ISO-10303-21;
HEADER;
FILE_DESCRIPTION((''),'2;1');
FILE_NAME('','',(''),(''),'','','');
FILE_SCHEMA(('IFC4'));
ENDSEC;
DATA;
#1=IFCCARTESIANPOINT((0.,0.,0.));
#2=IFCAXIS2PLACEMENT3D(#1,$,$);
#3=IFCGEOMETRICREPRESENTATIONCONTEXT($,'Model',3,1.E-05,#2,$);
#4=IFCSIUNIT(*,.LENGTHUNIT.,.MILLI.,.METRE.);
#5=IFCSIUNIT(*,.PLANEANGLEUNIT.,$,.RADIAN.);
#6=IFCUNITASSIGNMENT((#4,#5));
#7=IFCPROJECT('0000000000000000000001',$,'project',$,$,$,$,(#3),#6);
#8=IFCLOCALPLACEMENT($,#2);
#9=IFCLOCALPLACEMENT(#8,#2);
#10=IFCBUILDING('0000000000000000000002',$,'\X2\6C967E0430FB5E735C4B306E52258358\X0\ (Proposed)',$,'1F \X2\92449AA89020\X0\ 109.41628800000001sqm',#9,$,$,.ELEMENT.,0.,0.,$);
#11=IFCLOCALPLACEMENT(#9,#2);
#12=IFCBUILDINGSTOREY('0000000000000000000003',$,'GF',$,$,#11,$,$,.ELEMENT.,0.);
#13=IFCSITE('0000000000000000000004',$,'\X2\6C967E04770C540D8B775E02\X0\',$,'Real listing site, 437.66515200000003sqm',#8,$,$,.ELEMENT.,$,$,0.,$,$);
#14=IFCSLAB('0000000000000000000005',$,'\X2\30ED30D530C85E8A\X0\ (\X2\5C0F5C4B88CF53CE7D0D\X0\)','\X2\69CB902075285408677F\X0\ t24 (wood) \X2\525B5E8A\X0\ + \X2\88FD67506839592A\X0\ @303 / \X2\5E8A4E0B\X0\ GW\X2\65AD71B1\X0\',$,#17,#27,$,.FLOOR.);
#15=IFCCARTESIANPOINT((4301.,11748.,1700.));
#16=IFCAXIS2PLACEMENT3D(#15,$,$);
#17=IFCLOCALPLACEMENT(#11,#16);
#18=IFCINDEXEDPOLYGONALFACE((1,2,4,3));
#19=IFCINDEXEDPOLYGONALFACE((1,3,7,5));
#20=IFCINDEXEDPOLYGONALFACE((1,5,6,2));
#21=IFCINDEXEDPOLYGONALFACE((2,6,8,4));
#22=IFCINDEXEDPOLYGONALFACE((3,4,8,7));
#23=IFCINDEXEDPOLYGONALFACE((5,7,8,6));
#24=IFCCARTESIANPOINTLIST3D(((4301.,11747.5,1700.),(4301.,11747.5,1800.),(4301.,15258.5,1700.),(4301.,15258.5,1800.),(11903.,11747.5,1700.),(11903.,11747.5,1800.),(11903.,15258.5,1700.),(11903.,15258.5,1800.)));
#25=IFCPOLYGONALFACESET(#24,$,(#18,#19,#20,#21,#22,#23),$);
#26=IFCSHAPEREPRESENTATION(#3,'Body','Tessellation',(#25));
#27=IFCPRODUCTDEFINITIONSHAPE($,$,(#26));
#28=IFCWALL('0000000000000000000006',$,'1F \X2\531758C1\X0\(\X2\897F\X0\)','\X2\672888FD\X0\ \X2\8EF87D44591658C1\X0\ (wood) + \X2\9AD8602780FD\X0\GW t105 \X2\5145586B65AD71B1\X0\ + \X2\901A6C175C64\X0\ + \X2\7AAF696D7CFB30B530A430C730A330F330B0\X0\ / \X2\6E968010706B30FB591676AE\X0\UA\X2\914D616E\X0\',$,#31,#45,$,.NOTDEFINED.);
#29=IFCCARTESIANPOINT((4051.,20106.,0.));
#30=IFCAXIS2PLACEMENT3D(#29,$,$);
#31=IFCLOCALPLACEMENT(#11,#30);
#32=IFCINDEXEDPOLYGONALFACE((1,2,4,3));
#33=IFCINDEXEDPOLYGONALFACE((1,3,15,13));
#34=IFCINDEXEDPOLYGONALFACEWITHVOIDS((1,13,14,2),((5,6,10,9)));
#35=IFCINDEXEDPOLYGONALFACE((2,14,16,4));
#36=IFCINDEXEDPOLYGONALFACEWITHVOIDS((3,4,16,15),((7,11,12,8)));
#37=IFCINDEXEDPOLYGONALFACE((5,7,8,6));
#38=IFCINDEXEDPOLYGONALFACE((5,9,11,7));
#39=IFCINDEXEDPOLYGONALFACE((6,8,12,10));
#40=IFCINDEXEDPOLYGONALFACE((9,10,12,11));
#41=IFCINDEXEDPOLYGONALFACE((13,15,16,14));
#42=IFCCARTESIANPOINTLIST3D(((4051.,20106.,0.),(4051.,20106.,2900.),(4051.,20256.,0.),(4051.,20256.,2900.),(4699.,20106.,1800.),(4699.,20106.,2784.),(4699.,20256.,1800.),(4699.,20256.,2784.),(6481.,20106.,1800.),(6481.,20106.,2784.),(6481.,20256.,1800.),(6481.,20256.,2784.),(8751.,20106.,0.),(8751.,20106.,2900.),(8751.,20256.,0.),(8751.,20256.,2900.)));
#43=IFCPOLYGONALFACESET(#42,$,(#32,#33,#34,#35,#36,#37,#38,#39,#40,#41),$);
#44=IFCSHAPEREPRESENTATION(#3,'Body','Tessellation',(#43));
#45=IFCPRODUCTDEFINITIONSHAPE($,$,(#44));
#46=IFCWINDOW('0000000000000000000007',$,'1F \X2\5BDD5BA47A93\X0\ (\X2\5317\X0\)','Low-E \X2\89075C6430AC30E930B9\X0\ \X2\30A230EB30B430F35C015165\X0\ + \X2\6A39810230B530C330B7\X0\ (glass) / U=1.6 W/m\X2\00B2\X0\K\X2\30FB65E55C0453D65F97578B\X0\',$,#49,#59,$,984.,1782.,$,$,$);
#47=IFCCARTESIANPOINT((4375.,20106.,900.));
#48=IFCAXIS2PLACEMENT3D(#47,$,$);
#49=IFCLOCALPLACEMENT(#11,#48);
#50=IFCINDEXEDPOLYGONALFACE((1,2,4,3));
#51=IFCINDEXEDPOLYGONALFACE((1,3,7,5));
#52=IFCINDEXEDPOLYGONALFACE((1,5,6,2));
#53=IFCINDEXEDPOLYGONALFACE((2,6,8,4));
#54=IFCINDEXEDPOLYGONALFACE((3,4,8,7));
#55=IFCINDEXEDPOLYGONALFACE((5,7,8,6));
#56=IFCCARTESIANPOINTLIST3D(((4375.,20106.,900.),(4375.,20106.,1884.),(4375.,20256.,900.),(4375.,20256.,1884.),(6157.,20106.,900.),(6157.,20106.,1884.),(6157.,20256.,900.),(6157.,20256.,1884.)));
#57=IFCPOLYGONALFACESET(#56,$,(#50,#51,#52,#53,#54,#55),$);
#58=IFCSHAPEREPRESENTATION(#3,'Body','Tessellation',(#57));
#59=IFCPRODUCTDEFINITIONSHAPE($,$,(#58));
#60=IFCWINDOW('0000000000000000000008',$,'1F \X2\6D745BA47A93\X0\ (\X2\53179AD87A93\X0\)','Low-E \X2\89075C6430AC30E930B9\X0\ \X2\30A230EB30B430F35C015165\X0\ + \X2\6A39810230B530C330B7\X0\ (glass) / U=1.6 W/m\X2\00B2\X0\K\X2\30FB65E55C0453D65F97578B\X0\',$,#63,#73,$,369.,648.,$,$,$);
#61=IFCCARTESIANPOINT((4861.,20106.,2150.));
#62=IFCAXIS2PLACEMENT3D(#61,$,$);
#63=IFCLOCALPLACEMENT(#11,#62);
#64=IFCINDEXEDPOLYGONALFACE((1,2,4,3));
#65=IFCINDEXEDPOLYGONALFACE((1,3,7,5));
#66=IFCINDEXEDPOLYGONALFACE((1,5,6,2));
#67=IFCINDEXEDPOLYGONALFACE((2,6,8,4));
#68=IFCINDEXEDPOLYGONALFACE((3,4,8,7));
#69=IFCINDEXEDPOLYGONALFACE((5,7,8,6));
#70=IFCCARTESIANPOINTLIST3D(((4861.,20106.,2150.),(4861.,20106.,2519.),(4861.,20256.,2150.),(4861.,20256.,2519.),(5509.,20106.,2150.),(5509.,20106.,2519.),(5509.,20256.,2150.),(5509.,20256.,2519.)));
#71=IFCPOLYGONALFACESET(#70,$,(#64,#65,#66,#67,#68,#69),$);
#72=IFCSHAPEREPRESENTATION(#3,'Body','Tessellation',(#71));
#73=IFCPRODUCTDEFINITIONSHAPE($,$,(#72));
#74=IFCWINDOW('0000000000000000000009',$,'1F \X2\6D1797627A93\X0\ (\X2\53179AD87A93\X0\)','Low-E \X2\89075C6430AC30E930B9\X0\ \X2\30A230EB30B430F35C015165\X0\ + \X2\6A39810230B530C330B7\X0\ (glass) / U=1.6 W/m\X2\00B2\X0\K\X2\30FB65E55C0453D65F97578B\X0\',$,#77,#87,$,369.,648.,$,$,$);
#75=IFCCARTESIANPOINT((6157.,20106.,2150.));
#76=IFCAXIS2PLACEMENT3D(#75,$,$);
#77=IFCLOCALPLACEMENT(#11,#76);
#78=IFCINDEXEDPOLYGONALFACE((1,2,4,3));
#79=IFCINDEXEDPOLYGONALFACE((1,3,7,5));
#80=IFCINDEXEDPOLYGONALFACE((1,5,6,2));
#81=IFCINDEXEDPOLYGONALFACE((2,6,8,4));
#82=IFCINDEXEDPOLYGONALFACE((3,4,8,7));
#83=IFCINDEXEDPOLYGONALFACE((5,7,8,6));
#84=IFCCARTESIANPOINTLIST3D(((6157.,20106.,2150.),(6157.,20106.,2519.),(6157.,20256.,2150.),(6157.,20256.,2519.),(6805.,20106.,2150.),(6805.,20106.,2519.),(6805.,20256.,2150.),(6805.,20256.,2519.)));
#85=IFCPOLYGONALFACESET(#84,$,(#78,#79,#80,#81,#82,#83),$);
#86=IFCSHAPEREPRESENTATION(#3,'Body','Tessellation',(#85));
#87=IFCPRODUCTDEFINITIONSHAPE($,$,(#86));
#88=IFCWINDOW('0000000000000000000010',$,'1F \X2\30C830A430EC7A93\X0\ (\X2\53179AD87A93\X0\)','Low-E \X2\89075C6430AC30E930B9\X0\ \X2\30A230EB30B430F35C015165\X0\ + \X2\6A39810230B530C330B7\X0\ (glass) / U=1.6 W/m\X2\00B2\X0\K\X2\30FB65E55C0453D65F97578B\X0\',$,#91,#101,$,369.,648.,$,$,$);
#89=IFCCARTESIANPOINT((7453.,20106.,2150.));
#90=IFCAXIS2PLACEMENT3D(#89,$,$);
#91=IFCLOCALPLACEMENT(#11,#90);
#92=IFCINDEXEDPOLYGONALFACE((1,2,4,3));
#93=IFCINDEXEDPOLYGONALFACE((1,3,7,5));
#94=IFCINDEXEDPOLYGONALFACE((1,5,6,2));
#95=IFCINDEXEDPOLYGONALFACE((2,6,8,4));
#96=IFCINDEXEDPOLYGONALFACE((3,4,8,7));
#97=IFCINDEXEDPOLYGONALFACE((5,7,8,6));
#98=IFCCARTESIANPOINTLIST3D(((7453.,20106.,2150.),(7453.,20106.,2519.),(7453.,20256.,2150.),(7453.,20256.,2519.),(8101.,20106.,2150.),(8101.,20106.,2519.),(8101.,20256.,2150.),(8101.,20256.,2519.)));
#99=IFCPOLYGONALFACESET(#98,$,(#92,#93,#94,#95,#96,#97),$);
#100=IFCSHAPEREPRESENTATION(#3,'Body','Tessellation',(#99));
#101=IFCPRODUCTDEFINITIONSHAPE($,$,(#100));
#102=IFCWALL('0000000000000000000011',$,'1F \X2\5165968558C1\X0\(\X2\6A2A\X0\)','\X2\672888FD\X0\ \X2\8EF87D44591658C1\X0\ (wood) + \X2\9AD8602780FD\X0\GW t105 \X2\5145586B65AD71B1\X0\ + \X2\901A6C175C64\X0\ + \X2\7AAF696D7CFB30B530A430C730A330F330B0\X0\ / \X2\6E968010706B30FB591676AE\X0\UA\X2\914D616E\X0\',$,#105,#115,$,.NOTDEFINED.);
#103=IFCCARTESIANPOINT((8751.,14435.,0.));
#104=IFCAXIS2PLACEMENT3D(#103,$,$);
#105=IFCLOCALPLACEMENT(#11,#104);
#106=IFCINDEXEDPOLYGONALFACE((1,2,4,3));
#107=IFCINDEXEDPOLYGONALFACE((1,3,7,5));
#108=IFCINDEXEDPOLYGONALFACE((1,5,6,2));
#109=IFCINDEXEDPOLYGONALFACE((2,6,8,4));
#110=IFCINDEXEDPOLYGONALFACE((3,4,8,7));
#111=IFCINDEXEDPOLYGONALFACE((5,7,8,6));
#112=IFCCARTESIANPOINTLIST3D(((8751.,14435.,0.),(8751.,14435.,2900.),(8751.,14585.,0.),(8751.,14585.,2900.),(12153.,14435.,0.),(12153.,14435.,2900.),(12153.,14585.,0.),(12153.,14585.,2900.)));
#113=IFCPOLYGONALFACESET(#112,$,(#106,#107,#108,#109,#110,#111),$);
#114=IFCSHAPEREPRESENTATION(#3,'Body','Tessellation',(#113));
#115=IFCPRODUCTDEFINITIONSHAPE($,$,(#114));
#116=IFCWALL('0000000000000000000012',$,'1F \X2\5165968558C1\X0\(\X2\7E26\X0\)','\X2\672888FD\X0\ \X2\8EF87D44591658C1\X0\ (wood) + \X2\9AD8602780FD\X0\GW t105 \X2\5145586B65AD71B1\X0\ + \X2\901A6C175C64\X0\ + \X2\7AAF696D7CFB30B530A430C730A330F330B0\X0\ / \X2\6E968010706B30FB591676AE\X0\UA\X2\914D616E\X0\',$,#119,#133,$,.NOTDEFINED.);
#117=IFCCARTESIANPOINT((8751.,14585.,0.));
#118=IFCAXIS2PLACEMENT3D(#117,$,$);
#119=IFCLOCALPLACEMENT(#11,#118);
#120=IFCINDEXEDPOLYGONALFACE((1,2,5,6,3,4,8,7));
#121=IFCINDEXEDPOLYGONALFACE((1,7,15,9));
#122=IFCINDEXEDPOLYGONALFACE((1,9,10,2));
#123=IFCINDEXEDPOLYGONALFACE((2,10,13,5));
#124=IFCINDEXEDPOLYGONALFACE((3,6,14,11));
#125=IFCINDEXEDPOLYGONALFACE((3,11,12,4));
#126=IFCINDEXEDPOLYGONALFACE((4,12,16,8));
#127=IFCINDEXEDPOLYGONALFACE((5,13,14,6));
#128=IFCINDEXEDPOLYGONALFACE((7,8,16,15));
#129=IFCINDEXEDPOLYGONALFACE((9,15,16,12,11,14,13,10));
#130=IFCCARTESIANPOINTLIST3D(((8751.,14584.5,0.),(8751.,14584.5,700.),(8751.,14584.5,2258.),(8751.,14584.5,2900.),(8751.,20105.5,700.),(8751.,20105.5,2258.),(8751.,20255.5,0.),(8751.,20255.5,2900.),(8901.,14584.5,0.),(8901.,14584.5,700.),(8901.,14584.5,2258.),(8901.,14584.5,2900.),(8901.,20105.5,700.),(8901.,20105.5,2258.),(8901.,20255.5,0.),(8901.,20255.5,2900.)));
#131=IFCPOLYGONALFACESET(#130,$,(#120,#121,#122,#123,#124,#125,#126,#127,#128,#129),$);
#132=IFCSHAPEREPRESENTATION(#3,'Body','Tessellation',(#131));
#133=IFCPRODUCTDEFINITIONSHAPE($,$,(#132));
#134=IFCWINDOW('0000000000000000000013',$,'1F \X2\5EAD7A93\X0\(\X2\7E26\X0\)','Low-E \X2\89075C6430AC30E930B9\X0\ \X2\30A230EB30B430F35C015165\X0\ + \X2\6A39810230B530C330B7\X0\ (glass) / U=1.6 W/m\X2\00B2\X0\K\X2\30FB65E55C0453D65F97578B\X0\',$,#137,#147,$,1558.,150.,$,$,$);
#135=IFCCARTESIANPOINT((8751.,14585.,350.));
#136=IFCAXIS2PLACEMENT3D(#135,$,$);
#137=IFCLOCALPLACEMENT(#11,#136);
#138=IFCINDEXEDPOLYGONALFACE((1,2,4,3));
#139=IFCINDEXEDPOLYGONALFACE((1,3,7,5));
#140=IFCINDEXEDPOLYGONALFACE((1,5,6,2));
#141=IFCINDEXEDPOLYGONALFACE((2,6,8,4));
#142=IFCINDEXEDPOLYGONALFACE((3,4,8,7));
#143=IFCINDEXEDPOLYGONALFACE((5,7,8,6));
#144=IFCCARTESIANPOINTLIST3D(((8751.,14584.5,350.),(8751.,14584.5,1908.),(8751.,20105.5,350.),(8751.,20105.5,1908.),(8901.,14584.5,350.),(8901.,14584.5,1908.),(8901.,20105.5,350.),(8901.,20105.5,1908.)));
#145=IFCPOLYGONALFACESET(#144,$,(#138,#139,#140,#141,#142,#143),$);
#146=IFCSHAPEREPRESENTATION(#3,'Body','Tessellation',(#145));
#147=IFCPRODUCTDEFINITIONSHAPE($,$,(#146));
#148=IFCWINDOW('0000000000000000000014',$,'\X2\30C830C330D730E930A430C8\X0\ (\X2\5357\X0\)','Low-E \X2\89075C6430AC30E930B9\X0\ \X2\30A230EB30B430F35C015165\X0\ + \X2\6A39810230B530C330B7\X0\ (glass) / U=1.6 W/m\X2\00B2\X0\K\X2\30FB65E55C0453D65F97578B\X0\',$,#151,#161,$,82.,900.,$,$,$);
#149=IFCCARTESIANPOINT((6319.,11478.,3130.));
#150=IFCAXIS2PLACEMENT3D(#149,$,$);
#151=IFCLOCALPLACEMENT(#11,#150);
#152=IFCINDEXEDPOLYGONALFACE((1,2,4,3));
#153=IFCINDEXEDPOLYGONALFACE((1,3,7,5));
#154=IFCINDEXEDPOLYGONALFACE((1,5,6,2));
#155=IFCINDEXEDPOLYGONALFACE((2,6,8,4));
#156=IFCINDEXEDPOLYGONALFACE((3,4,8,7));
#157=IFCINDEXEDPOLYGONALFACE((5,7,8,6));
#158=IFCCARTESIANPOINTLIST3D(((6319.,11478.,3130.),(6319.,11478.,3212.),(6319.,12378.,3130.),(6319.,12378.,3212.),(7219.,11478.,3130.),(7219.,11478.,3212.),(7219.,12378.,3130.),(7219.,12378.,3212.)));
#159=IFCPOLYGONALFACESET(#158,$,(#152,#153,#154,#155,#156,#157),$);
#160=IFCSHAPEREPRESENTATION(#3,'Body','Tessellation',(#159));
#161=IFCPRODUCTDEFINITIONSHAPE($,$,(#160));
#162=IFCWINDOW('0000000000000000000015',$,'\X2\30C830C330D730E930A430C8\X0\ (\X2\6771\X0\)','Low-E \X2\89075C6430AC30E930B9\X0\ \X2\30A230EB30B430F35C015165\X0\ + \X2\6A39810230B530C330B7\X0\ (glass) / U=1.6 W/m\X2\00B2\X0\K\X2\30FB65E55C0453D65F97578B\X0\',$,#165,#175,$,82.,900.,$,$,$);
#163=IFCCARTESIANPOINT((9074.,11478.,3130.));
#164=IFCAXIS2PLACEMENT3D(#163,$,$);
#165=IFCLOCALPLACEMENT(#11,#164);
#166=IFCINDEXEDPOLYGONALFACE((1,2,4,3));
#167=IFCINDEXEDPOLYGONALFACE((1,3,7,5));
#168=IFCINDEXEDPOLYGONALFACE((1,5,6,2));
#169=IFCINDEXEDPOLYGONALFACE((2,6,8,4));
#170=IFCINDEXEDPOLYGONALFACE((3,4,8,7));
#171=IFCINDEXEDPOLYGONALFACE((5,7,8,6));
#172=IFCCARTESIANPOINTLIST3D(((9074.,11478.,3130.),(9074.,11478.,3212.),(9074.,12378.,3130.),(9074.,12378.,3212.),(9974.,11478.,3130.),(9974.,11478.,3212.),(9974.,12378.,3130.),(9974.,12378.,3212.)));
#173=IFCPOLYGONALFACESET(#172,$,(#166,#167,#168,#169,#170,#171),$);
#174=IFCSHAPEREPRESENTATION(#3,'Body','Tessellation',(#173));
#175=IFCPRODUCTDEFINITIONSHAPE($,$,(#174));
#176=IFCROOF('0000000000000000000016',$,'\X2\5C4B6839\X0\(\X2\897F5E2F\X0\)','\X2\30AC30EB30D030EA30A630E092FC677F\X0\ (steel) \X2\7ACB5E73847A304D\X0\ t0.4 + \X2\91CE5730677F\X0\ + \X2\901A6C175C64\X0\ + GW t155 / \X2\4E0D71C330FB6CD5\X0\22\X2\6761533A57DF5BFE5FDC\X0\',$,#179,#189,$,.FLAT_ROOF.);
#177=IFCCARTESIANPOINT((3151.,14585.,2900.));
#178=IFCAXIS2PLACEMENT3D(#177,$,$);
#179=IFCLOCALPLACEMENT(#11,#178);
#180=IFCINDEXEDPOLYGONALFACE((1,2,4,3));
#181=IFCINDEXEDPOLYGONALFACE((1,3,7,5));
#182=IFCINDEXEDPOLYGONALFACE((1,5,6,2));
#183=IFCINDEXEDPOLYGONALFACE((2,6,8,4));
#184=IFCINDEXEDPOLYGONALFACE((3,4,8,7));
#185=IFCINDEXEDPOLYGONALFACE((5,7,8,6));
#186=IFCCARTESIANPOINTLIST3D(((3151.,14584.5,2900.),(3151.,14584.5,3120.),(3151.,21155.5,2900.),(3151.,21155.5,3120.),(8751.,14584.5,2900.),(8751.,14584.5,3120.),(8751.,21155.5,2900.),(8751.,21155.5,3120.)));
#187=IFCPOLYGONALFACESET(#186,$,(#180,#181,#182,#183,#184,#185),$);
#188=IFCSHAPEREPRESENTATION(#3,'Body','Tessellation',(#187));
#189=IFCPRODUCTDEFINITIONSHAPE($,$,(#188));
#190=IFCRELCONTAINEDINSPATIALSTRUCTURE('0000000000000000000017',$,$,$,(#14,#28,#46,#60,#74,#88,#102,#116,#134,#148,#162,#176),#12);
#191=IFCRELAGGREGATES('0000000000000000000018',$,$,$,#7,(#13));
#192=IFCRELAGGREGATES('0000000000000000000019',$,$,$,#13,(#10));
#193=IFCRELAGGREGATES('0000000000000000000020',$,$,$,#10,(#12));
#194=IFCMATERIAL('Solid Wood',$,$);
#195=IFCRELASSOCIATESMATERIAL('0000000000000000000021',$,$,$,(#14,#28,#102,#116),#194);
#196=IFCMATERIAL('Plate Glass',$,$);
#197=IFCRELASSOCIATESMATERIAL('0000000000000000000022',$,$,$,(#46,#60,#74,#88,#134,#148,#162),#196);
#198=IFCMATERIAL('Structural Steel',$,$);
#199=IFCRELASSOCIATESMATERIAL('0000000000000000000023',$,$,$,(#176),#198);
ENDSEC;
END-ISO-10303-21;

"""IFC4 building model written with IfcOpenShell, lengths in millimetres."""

from ifc_helpers import new_model, si_unit, frame, frame_2d, origin, place, context, project, spatial, rectangle, extrude, material, element, fill, save


model = new_model("IFC4")

# Units and contexts
model_context = context("Model", 3, precision=1e-05, world=origin())
ifc_project = project(units=[si_unit("LENGTHUNIT", "METRE", prefix="MILLI"), si_unit("PLANEANGLEUNIT", "RADIAN")], contexts=[model_context])

# Site, building, storey
site_placement = place(None, origin())
site = spatial("IfcSite", under=ifc_project, at=site_placement, Name="沖縄県名護市", ObjectType="Real listing site, 437.66515200000003sqm", CompositionType="ELEMENT", RefElevation=0.0)
building_placement = place(site_placement, origin())
building = spatial("IfcBuilding", under=site, at=building_placement, Name="沖縄・平屋の別荘 (Proposed)", ObjectType="1F 鉄骨造 109.41628800000001sqm", CompositionType="ELEMENT", ElevationOfRefHeight=0.0, ElevationOfTerrain=0.0)
storey_placement = place(building_placement, origin())
storey = spatial("IfcBuildingStorey", under=building, at=storey_placement, Name="GF", CompositionType="ELEMENT", Elevation=0.0)

# Slab
ifc_material_1 = material(Name="Solid Wood")
slab_1_placement = place(storey_placement, frame((4301.0, 11748.0, 1700.0)))
element("IfcSlab", 1, at=slab_1_placement, inside=storey, material=ifc_material_1, Name="ロフト床 (小屋裏収納)", Description="構造用合板 t24 (wood) 剛床 + 製材根太 @303 / 床下 GW断熱", PredefinedType="FLOOR", context=model_context, shape_type="SweptSolid", body=[
    extrude(rectangle(XDim=7602.0, YDim=3511.0, at=frame_2d((3801.0, 1755.0))), frame((4301.0, 11748.0, 1700.0)), (0.0, 0.0, 1.0), 100.0),
])

# Wall, openings, windows
wall_1_placement = place(storey_placement, frame((4051.0, 20106.0, 0.0)))
wall_1 = element("IfcWall", 2, at=wall_1_placement, inside=storey, material=ifc_material_1, Name="1F 北壁(西)", Description="木製 軸組外壁 (wood) + 高性能GW t105 充填断熱 + 通気層 + 窯業系サイディング / 準耐火・外皮UA配慮", PredefinedType="NOTDEFINED", context=model_context, shape_type="SweptSolid", body=[
    extrude(rectangle(XDim=4700.0, YDim=150.0, at=frame_2d((2350.0, 75.0))), frame((4051.0, 20106.0, 0.0)), (0.0, 0.0, 1.0), 2900.0),
])
opening_1_placement = place(storey_placement, frame((4375.0, 20106.0, 900.0)))
opening_1 = element("IfcOpeningElement", 3, at=opening_1_placement, cuts=wall_1, PredefinedType="NOTDEFINED", context=model_context, shape_type="SweptSolid", body=[
    extrude(rectangle(XDim=1782.0, YDim=150.0, at=frame_2d((891.0, 75.0))), frame((4375.0, 20106.0, 900.0)), (0.0, 0.0, 1.0), 984.0),
])
opening_2_placement = place(storey_placement, frame((4861.0, 20106.0, 2150.0)))
opening_2 = element("IfcOpeningElement", 4, at=opening_2_placement, cuts=wall_1, PredefinedType="NOTDEFINED", context=model_context, shape_type="SweptSolid", body=[
    extrude(rectangle(XDim=648.0, YDim=150.0, at=frame_2d((324.0, 75.0))), frame((4861.0, 20106.0, 2150.0)), (0.0, 0.0, 1.0), 369.0),
])
opening_3_placement = place(storey_placement, frame((6157.0, 20106.0, 2150.0)))
opening_3 = element("IfcOpeningElement", 5, at=opening_3_placement, cuts=wall_1, PredefinedType="NOTDEFINED", context=model_context, shape_type="SweptSolid", body=[
    extrude(rectangle(XDim=648.0, YDim=150.0, at=frame_2d((324.0, 75.0))), frame((6157.0, 20106.0, 2150.0)), (0.0, 0.0, 1.0), 369.0),
])
opening_4_placement = place(storey_placement, frame((7453.0, 20106.0, 2150.0)))
opening_4 = element("IfcOpeningElement", 6, at=opening_4_placement, cuts=wall_1, PredefinedType="NOTDEFINED", context=model_context, shape_type="SweptSolid", body=[
    extrude(rectangle(XDim=648.0, YDim=150.0, at=frame_2d((324.0, 75.0))), frame((7453.0, 20106.0, 2150.0)), (0.0, 0.0, 1.0), 369.0),
])
ifc_material_2 = material(Name="Plate Glass")
window_1_placement = place(storey_placement, frame((4375.0, 20106.0, 900.0)))
window_1 = element("IfcWindow", 7, at=window_1_placement, inside=storey, material=ifc_material_2, Name="1F 寝室窓 (北)", Description="Low-E 複層ガラス アルゴン封入 + 樹脂サッシ (glass) / U=1.6 W/m²K・日射取得型", OverallHeight=984.0, OverallWidth=1782.0, context=model_context, shape_type="SweptSolid", body=[
    extrude(rectangle(XDim=1782.0, YDim=150.0, at=frame_2d((891.0, 75.0))), frame((4375.0, 20106.0, 900.0)), (0.0, 0.0, 1.0), 984.0),
])
fill(opening_1, window_1)
window_2_placement = place(storey_placement, frame((4861.0, 20106.0, 2150.0)))
window_2 = element("IfcWindow", 8, at=window_2_placement, inside=storey, material=ifc_material_2, Name="1F 浴室窓 (北高窓)", Description="Low-E 複層ガラス アルゴン封入 + 樹脂サッシ (glass) / U=1.6 W/m²K・日射取得型", OverallHeight=369.0, OverallWidth=648.0, context=model_context, shape_type="SweptSolid", body=[
    extrude(rectangle(XDim=648.0, YDim=150.0, at=frame_2d((324.0, 75.0))), frame((4861.0, 20106.0, 2150.0)), (0.0, 0.0, 1.0), 369.0),
])
fill(opening_2, window_2)
window_3_placement = place(storey_placement, frame((6157.0, 20106.0, 2150.0)))
window_3 = element("IfcWindow", 9, at=window_3_placement, inside=storey, material=ifc_material_2, Name="1F 洗面窓 (北高窓)", Description="Low-E 複層ガラス アルゴン封入 + 樹脂サッシ (glass) / U=1.6 W/m²K・日射取得型", OverallHeight=369.0, OverallWidth=648.0, context=model_context, shape_type="SweptSolid", body=[
    extrude(rectangle(XDim=648.0, YDim=150.0, at=frame_2d((324.0, 75.0))), frame((6157.0, 20106.0, 2150.0)), (0.0, 0.0, 1.0), 369.0),
])
fill(opening_3, window_3)
window_4_placement = place(storey_placement, frame((7453.0, 20106.0, 2150.0)))
window_4 = element("IfcWindow", 10, at=window_4_placement, inside=storey, material=ifc_material_2, Name="1F トイレ窓 (北高窓)", Description="Low-E 複層ガラス アルゴン封入 + 樹脂サッシ (glass) / U=1.6 W/m²K・日射取得型", OverallHeight=369.0, OverallWidth=648.0, context=model_context, shape_type="SweptSolid", body=[
    extrude(rectangle(XDim=648.0, YDim=150.0, at=frame_2d((324.0, 75.0))), frame((7453.0, 20106.0, 2150.0)), (0.0, 0.0, 1.0), 369.0),
])
fill(opening_4, window_4)

# Wall
wall_2_placement = place(storey_placement, frame((8751.0, 14435.0, 0.0)))
element("IfcWall", 11, at=wall_2_placement, inside=storey, material=ifc_material_1, Name="1F 入隅壁(横)", Description="木製 軸組外壁 (wood) + 高性能GW t105 充填断熱 + 通気層 + 窯業系サイディング / 準耐火・外皮UA配慮", PredefinedType="NOTDEFINED", context=model_context, shape_type="SweptSolid", body=[
    extrude(rectangle(XDim=3402.0, YDim=150.0, at=frame_2d((1701.0, 75.0))), frame((8751.0, 14435.0, 0.0)), (0.0, 0.0, 1.0), 2900.0),
])

# Wall, opening, window
wall_3_placement = place(storey_placement, frame((8751.0, 14585.0, 0.0)))
wall_3 = element("IfcWall", 12, at=wall_3_placement, inside=storey, material=ifc_material_1, Name="1F 入隅壁(縦)", Description="木製 軸組外壁 (wood) + 高性能GW t105 充填断熱 + 通気層 + 窯業系サイディング / 準耐火・外皮UA配慮", PredefinedType="NOTDEFINED", context=model_context, shape_type="SweptSolid", body=[
    extrude(rectangle(XDim=150.0, YDim=5671.0, at=frame_2d((75.0, 2835.0))), frame((8751.0, 14585.0, 0.0)), (0.0, 0.0, 1.0), 2900.0),
])
opening_5_placement = place(storey_placement, frame((8751.0, 14585.0, 350.0)))
opening_5 = element("IfcOpeningElement", 13, at=opening_5_placement, cuts=wall_3, PredefinedType="NOTDEFINED", context=model_context, shape_type="SweptSolid", body=[
    extrude(rectangle(XDim=150.0, YDim=5521.0, at=frame_2d((75.0, 2760.0))), frame((8751.0, 14585.0, 350.0)), (0.0, 0.0, 1.0), 1558.0),
])
window_5_placement = place(storey_placement, frame((8751.0, 14585.0, 350.0)))
window_5 = element("IfcWindow", 14, at=window_5_placement, inside=storey, material=ifc_material_2, Name="1F 庭窓(縦)", Description="Low-E 複層ガラス アルゴン封入 + 樹脂サッシ (glass) / U=1.6 W/m²K・日射取得型", OverallHeight=1558.0, OverallWidth=150.0, context=model_context, shape_type="SweptSolid", body=[
    extrude(rectangle(XDim=150.0, YDim=5521.0, at=frame_2d((75.0, 2760.0))), frame((8751.0, 14585.0, 350.0)), (0.0, 0.0, 1.0), 1558.0),
])
fill(opening_5, window_5)

# Windows
window_6_placement = place(storey_placement, frame((6319.0, 11478.0, 3130.0)))
element("IfcWindow", 15, at=window_6_placement, inside=storey, material=ifc_material_2, Name="トップライト (南)", Description="Low-E 複層ガラス アルゴン封入 + 樹脂サッシ (glass) / U=1.6 W/m²K・日射取得型", OverallHeight=82.0, OverallWidth=900.0, context=model_context, shape_type="SweptSolid", body=[
    extrude(rectangle(XDim=900.0, YDim=900.0, at=frame_2d((450.0, 450.0))), frame((6319.0, 11478.0, 3130.0)), (0.0, 0.0, 1.0), 82.0),
])
window_7_placement = place(storey_placement, frame((9074.0, 11478.0, 3130.0)))
element("IfcWindow", 16, at=window_7_placement, inside=storey, material=ifc_material_2, Name="トップライト (東)", Description="Low-E 複層ガラス アルゴン封入 + 樹脂サッシ (glass) / U=1.6 W/m²K・日射取得型", OverallHeight=82.0, OverallWidth=900.0, context=model_context, shape_type="SweptSolid", body=[
    extrude(rectangle(XDim=900.0, YDim=900.0, at=frame_2d((450.0, 450.0))), frame((9074.0, 11478.0, 3130.0)), (0.0, 0.0, 1.0), 82.0),
])

# Roof
ifc_material_3 = material(Name="Structural Steel")
roof_placement = place(storey_placement, frame((3151.0, 14585.0, 2900.0)))
element("IfcRoof", 17, at=roof_placement, inside=storey, material=ifc_material_3, Name="屋根(西帯)", Description="ガルバリウム鋼板 (steel) 立平葺き t0.4 + 野地板 + 通気層 + GW t155 / 不燃・法22条区域対応", PredefinedType="FLAT_ROOF", context=model_context, shape_type="SweptSolid", body=[
    extrude(rectangle(XDim=5600.0, YDim=6571.0, at=frame_2d((2800.0, 3285.0))), frame((3151.0, 14585.0, 2900.0)), (0.0, 0.0, 1.0), 220.0),
])

save(model, "model.ifc")
